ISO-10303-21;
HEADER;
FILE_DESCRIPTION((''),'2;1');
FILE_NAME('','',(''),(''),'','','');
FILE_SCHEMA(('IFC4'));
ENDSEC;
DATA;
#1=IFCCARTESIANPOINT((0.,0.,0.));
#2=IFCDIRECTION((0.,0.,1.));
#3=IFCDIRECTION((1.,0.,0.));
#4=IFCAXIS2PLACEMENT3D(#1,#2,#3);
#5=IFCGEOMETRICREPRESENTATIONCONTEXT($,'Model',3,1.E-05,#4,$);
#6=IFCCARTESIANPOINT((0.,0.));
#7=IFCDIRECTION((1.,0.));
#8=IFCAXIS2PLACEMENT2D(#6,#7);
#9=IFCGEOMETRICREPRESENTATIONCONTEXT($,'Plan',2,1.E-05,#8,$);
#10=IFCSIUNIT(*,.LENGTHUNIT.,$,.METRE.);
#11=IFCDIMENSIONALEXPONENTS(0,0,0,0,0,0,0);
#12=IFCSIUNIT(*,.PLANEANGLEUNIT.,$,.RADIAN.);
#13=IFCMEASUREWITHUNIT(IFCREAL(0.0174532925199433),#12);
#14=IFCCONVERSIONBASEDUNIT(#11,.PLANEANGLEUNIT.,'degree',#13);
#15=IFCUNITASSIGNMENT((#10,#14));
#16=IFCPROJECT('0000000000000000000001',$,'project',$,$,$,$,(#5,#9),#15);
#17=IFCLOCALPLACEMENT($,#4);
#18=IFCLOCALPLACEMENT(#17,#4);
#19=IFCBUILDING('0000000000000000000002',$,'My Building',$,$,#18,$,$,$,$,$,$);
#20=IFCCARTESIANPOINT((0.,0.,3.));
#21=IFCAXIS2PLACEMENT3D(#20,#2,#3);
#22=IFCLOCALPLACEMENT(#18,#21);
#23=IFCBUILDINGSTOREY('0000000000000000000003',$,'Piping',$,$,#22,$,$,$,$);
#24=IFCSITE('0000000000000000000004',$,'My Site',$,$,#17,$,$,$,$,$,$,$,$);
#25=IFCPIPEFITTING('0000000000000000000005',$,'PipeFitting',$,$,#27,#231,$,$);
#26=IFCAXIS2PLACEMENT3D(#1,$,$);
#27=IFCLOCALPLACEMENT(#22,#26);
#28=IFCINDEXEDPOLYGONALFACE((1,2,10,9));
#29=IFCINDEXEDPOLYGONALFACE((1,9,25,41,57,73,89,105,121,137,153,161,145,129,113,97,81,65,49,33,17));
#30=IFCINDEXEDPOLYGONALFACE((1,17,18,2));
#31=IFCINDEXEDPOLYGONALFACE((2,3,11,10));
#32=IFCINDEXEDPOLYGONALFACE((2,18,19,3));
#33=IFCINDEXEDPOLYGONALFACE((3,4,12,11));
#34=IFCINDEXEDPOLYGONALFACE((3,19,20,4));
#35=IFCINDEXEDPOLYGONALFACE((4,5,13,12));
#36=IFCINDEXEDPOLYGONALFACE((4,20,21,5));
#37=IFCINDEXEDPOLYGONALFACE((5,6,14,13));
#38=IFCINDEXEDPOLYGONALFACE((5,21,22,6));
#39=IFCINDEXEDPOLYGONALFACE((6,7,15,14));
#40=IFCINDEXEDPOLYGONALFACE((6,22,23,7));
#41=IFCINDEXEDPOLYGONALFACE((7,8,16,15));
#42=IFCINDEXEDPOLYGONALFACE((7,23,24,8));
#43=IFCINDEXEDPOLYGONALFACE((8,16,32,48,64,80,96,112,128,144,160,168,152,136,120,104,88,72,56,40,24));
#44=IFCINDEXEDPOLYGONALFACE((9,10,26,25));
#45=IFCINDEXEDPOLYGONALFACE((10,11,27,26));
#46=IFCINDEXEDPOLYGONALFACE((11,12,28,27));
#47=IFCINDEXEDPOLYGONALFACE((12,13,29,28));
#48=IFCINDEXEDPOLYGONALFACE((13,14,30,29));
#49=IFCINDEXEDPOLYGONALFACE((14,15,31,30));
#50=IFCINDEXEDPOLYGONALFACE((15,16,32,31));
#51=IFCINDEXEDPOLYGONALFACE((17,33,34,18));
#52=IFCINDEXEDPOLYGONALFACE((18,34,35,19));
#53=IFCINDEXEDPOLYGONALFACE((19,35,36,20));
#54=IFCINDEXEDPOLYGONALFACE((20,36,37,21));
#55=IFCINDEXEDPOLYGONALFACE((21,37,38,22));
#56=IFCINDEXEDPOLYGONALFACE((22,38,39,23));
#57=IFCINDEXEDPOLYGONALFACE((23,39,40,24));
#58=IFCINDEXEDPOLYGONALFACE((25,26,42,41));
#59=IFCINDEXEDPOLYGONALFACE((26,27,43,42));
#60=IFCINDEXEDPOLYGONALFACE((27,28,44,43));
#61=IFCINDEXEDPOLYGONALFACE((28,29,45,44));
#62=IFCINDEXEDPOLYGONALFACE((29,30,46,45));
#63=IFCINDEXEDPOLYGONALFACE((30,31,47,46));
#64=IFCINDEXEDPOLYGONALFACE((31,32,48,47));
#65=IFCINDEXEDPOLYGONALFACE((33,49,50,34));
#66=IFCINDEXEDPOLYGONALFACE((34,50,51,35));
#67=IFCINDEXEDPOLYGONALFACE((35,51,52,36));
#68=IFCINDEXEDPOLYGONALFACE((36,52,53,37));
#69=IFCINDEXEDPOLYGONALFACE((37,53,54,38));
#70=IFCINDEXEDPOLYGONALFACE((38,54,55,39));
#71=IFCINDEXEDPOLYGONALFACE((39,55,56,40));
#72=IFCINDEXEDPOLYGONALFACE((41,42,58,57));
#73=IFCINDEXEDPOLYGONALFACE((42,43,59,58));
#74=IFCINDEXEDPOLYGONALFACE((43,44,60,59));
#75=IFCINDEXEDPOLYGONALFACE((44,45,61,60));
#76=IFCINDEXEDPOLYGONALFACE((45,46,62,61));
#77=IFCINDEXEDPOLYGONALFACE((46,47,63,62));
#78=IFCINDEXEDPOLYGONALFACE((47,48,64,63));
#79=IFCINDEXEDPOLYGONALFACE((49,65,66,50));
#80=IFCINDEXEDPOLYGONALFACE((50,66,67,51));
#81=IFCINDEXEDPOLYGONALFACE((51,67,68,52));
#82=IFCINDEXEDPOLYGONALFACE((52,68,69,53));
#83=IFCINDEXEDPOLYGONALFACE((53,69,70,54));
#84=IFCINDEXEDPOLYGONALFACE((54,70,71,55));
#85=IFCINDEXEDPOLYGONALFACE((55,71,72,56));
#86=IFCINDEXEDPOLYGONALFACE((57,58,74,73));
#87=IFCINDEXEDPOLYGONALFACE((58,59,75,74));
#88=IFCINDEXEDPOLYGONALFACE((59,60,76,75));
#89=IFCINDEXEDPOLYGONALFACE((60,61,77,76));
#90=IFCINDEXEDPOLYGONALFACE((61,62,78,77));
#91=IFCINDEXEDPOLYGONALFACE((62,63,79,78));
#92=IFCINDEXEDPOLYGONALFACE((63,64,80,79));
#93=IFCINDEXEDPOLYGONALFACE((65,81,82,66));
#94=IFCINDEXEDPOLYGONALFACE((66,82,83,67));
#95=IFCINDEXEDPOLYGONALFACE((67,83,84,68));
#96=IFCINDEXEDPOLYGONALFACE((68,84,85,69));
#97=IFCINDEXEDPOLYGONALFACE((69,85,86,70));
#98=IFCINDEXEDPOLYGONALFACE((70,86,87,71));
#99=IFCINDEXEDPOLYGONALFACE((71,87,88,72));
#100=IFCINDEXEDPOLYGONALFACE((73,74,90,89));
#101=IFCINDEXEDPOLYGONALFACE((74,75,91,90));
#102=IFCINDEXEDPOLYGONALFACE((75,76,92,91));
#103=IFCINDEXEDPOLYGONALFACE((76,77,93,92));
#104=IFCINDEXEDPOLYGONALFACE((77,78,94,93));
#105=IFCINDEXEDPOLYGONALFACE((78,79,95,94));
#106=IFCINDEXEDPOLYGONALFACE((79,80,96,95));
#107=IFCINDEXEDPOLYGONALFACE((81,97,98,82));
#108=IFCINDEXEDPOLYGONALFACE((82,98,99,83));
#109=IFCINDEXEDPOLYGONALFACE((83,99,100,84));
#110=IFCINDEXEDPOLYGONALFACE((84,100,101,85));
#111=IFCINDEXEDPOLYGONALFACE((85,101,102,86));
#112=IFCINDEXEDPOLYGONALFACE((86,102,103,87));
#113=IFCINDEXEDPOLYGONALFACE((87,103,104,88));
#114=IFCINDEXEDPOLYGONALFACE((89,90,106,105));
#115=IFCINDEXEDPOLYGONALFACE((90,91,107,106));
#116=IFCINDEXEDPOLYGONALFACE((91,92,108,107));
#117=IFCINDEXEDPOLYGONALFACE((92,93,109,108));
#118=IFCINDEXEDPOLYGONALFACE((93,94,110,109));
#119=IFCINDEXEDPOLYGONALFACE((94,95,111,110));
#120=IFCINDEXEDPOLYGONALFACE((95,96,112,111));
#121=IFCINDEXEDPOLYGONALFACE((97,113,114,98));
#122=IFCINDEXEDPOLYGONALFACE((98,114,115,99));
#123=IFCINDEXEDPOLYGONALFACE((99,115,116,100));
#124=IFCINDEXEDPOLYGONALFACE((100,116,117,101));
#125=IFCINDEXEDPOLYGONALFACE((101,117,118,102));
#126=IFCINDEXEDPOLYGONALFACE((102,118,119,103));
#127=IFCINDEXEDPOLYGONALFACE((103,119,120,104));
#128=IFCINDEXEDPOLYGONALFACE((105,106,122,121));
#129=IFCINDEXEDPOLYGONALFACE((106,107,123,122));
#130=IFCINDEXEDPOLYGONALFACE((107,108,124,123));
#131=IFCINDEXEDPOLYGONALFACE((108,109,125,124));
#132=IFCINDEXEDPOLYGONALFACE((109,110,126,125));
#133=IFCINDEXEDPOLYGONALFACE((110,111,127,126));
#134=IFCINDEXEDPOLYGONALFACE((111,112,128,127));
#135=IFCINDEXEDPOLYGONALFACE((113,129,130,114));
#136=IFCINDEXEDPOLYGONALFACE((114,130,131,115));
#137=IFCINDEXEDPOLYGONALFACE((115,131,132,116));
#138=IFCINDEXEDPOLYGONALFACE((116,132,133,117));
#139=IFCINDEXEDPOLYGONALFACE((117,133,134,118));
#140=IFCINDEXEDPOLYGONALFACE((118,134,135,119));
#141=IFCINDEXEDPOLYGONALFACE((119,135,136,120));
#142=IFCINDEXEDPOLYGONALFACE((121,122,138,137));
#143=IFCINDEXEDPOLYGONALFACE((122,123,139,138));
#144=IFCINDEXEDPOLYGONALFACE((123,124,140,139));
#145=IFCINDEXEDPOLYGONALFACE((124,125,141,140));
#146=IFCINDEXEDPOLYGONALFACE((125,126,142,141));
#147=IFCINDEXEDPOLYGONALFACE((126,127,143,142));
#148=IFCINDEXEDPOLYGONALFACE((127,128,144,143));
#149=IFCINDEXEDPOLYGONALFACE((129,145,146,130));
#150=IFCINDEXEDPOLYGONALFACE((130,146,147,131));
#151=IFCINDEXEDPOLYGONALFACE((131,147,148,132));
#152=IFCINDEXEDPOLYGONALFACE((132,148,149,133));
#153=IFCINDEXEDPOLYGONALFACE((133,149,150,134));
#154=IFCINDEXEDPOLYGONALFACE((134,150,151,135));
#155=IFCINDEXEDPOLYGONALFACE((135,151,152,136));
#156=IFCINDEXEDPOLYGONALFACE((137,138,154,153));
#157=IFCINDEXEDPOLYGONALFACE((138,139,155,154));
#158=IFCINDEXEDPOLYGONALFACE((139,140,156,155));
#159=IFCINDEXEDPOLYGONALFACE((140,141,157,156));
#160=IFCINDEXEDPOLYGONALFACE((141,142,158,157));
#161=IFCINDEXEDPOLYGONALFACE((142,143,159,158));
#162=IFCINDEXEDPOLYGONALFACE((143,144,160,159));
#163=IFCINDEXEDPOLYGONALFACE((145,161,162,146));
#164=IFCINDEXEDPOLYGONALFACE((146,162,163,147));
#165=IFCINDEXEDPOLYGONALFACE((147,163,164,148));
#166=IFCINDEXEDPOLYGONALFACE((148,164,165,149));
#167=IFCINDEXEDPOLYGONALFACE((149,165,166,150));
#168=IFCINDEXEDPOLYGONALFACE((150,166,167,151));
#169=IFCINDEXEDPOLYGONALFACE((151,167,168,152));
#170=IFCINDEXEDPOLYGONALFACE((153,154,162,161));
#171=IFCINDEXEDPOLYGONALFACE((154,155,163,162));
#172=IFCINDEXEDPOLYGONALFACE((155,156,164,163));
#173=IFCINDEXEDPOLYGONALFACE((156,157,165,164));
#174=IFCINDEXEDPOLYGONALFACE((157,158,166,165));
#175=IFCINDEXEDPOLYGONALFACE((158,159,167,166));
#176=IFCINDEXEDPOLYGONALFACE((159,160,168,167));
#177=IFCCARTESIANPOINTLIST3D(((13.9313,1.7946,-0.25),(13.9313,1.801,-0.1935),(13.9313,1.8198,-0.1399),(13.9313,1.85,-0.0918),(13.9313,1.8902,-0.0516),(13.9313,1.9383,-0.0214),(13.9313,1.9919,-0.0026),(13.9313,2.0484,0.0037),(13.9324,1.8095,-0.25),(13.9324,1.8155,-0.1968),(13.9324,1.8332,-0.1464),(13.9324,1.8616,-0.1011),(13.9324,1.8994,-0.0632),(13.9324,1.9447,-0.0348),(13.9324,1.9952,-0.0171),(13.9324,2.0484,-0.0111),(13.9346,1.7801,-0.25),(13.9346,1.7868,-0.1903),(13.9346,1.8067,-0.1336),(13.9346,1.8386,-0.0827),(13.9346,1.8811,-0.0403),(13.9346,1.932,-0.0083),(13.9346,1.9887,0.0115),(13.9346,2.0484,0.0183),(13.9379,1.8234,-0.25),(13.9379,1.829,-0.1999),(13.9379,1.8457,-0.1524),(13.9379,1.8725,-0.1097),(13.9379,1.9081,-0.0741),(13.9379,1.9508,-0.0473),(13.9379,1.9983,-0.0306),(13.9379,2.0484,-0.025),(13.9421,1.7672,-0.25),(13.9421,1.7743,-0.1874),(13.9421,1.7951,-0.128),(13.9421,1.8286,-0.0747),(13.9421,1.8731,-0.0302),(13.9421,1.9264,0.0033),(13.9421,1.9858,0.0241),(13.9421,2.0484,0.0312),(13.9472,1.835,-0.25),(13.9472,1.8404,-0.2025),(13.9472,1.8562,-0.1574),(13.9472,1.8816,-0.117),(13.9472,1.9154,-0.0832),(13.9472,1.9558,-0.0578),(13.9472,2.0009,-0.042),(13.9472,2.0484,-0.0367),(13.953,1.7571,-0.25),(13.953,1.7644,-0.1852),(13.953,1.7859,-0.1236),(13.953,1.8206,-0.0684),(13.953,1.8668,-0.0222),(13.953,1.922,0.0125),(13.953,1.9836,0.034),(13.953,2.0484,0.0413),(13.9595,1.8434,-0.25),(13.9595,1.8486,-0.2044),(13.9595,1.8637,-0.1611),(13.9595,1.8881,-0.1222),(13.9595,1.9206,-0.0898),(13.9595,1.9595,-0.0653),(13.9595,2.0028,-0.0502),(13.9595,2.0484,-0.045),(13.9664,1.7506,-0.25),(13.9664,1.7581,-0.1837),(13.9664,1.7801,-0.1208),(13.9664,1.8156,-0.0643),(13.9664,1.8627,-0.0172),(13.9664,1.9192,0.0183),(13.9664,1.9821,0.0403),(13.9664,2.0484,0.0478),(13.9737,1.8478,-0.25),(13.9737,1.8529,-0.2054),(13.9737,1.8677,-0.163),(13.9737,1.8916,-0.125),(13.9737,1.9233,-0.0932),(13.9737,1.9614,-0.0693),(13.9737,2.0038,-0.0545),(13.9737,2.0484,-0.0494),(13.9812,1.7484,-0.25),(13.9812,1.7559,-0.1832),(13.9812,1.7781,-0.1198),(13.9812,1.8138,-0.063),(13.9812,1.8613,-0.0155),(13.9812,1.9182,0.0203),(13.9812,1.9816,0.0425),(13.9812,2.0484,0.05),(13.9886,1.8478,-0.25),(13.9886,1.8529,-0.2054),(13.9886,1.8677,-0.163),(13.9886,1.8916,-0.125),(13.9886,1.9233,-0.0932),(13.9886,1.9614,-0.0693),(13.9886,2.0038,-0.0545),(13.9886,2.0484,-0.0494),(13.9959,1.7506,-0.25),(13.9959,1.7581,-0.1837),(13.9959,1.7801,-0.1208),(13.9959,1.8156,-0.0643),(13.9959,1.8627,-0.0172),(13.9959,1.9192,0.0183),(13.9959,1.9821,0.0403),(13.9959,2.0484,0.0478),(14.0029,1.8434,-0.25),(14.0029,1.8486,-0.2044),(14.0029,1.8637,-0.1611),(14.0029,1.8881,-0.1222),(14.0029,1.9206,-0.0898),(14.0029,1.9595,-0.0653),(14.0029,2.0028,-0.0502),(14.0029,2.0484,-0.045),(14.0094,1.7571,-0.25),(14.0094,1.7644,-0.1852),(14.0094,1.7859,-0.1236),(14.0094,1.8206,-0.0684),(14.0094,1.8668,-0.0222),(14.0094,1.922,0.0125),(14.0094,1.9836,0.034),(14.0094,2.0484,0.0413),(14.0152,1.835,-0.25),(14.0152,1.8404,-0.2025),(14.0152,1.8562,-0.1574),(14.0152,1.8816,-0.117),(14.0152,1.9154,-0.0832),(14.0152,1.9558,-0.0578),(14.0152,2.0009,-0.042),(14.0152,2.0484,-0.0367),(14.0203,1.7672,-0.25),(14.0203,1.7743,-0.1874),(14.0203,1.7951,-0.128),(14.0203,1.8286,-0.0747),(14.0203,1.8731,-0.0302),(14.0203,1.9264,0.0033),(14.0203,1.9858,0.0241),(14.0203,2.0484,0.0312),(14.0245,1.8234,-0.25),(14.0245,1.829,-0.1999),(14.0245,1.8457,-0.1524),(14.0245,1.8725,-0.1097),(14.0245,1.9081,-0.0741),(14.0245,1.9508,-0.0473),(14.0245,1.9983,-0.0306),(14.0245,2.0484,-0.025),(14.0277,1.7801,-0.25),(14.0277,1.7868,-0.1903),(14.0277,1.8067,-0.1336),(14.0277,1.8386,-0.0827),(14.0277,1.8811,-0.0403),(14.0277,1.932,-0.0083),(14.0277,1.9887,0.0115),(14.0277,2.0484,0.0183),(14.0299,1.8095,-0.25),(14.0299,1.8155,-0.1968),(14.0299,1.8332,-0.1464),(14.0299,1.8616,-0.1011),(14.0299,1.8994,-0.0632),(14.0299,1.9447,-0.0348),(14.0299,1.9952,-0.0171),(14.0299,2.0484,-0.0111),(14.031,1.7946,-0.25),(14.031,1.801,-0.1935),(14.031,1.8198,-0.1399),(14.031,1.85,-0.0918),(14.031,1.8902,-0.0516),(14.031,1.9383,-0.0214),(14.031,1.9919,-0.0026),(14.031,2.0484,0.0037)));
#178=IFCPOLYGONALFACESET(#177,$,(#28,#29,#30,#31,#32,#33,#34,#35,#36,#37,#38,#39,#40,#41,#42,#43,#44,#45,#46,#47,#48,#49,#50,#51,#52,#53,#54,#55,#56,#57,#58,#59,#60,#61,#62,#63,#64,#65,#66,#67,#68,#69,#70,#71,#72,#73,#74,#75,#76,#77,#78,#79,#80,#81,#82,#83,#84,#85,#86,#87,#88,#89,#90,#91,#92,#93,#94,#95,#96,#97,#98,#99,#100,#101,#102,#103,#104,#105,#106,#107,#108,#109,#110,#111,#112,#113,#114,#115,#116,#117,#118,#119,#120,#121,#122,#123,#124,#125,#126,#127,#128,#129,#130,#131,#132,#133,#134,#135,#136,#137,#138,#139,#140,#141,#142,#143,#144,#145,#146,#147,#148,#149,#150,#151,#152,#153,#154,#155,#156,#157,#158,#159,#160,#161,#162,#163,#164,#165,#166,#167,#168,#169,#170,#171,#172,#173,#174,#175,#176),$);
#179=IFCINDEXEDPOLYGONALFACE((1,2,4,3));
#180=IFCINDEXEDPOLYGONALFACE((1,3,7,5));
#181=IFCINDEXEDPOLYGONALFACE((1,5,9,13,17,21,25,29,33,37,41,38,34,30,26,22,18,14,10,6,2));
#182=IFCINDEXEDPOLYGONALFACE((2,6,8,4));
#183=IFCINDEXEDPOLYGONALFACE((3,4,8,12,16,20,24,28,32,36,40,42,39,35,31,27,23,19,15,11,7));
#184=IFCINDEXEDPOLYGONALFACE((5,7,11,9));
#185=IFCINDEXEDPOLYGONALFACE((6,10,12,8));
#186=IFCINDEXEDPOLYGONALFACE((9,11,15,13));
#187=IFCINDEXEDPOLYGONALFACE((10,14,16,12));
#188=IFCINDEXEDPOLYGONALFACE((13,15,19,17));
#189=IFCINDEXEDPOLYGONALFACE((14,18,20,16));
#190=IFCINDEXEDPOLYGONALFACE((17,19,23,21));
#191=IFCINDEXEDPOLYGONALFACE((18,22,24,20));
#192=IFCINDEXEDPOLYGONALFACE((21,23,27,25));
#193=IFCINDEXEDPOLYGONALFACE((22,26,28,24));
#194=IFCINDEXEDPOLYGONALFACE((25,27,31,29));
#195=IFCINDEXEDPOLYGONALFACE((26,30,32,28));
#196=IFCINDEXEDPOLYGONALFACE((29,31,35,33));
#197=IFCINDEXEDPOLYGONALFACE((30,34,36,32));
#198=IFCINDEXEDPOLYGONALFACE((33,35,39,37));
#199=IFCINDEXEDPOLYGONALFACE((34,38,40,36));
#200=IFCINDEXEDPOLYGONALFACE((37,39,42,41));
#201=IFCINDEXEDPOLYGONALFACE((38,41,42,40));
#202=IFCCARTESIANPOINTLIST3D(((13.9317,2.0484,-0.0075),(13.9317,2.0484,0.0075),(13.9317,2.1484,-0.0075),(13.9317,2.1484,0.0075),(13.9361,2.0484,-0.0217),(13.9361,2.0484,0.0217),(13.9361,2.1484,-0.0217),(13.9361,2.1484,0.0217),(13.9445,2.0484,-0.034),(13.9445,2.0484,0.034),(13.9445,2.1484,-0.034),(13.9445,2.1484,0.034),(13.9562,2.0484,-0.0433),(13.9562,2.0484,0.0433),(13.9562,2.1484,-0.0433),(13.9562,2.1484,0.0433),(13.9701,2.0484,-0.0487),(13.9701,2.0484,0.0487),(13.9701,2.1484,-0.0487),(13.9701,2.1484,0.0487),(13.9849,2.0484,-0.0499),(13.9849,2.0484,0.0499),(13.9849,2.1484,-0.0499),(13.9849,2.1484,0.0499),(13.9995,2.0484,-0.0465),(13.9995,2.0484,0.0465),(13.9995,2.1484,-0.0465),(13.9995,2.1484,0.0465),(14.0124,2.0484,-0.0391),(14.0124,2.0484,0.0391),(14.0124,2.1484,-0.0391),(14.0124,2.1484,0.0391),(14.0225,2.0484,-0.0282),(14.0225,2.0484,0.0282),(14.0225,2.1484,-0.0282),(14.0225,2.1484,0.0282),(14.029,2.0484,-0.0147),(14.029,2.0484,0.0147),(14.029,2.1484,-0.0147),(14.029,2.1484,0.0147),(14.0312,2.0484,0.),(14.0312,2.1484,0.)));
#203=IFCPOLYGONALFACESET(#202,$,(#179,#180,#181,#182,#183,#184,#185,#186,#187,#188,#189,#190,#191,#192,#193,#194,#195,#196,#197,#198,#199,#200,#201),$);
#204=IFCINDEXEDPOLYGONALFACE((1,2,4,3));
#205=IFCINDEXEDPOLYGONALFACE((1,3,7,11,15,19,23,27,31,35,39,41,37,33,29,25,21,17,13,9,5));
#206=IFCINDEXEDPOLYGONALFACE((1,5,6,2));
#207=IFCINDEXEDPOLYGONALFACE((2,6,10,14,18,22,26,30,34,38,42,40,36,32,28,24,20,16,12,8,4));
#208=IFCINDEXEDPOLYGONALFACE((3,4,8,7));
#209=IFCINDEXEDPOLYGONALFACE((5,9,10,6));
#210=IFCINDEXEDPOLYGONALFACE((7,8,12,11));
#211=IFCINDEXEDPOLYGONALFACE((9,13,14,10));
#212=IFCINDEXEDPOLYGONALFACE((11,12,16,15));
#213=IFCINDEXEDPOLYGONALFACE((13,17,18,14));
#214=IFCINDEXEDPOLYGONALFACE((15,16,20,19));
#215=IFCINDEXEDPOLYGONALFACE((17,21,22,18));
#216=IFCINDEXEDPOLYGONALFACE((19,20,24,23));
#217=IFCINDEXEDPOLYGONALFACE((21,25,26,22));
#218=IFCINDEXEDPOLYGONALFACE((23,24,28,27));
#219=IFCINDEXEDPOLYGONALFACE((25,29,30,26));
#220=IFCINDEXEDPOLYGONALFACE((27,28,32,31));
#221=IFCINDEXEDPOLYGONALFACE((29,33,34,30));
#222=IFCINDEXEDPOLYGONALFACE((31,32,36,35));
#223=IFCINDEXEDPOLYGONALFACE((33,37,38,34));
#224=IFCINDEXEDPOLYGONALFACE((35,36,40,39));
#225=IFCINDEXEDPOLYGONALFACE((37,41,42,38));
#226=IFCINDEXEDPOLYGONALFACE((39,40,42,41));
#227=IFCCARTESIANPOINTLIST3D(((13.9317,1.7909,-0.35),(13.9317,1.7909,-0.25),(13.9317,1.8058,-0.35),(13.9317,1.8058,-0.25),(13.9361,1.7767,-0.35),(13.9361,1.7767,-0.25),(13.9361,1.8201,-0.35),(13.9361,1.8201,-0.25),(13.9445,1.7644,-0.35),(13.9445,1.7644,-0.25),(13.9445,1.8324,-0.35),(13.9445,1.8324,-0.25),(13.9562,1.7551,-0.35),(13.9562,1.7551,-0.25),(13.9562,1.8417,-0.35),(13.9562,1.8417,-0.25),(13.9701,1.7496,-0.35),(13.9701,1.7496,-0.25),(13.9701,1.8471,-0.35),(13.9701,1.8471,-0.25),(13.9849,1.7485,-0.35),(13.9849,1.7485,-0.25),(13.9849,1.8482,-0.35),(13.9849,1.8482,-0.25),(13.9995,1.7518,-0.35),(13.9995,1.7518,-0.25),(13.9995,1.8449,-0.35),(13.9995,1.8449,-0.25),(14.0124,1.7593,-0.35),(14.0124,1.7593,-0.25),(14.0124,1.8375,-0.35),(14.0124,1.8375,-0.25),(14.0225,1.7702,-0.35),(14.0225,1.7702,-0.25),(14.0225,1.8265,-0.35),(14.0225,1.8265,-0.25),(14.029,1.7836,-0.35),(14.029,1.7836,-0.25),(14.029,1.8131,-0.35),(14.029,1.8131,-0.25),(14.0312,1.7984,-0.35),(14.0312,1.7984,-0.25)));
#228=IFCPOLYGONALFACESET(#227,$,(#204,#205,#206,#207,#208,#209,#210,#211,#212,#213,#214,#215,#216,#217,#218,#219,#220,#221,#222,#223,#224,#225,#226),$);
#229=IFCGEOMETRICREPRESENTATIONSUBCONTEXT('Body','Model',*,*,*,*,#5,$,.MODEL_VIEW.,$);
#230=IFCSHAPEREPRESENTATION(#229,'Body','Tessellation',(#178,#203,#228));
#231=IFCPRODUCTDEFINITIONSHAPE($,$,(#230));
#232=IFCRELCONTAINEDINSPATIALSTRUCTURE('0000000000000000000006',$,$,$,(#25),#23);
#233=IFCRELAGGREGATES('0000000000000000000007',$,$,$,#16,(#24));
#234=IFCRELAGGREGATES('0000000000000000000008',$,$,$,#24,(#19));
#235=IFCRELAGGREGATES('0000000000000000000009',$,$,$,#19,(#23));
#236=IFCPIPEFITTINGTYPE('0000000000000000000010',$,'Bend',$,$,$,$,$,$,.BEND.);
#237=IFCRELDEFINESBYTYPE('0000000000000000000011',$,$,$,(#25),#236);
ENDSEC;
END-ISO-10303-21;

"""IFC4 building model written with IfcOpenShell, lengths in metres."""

from ifc_helpers import new_model, entity, si_unit, converted_unit, frame, origin_with_axes, origin_2d_with_axis, place, context, subcontext, project, spatial, line, indexed_curve, circle, outline, extrude, source, transform, mapped, type_object, type_shapes, element, save


model = new_model("IFC4")

# Units and contexts
model_context = context("Model", 3, precision=1e-05, world=origin_with_axes())
plan_context = context("Plan", 2, precision=1e-05, world=origin_2d_with_axis())
body_context = subcontext(model_context, "Body", "Model", "MODEL_VIEW")
ifc_project = project(units=[si_unit("LENGTHUNIT", "METRE"), converted_unit("PLANEANGLEUNIT", "degree", entity("IfcReal", 0.0174532925199433), si_unit("PLANEANGLEUNIT", "RADIAN"), dimensions=[0, 0, 0, 0, 0, 0, 0])], contexts=[model_context, plan_context])

# Site, building, storey
site_placement = place(None, origin_with_axes())
site = spatial("IfcSite", under=ifc_project, at=site_placement, Name="My Site")
building_placement = place(site_placement, origin_with_axes())
building = spatial("IfcBuilding", under=site, at=building_placement, Name="My Building")
storey_placement = place(building_placement, frame((0.0, 0.0, 3.0), z_axis=(0.0, 0.0, 1.0), x_axis=(1.0, 0.0, 0.0)))
storey = spatial("IfcBuildingStorey", under=building, at=storey_placement, Name="Piping")

# Pipe fitting, opening
pipe_fitting_type = type_object("IfcPipeFittingType", Name="Bend", PredefinedType="BEND")
shared_shape = source(origin_with_axes(), body_context, "Body", "SolidModel", [
    entity("IfcSweptDiskSolid", entity("IfcIndexedPolyCurve", entity("IfcCartesianPointList3D", [[0.0, 0.0, 0.1], [0.0, -0.0732, 0.2768], [0.0, -0.25, 0.35]]), [entity("IfcArcIndex", [1, 2, 3])]), 0.05),
    extrude(circle(Radius=0.05), origin_with_axes(), (0.0, 0.0, 1.0), 0.1),
    extrude(circle(Radius=0.05), frame((0.0, -0.25, 0.35), z_axis=(0.0, -1.0, 0.0), x_axis=(1.0, 0.0, 0.0)), (0.0, 0.0, 1.0), 0.1),
])
type_shapes(pipe_fitting_type, [shared_shape])
pipe_fitting_1_placement = place(storey_placement, frame((13.9812, 2.1484, 0.0), z_axis=(0.0, -1.0, 0.0), x_axis=(1.0, 0.0, 0.0)))
pipe_fitting_1 = element("IfcPipeFitting", 1, at=pipe_fitting_1_placement, inside=storey, type_object=pipe_fitting_type, Name="PipeFitting", context=body_context, shape_type="MappedRepresentation", body=[
    mapped(shared_shape, transform((0.0, 0.0, 0.0), x_axis=(1.0, 0.0, 0.0), y_axis=(0.0, 1.0, 0.0), z_axis=(0.0, 0.0, 1.0), scale=1.0)),
])
opening_1_placement = place(pipe_fitting_1_placement, frame((-13.9812, -3.0, 2.1484), z_axis=(0.0, 1.0, 0.0), x_axis=(1.0, 0.0, 0.0)))
element("IfcOpeningElement", 2, at=opening_1_placement, cuts=pipe_fitting_1, PredefinedType="OPENING", context=body_context, shape_type="SweptSolid", body=[
    extrude(outline(indexed_curve([(0.0, 0.0), (0.5, 0.0), (0.5, 0.5), (0.0, 0.5)], segments=[line(1, 2, 3, 4, 1)])), origin_with_axes(), (0.0, 0.0, 1.0), 0.5),
])

save(model, "model.ifc")
